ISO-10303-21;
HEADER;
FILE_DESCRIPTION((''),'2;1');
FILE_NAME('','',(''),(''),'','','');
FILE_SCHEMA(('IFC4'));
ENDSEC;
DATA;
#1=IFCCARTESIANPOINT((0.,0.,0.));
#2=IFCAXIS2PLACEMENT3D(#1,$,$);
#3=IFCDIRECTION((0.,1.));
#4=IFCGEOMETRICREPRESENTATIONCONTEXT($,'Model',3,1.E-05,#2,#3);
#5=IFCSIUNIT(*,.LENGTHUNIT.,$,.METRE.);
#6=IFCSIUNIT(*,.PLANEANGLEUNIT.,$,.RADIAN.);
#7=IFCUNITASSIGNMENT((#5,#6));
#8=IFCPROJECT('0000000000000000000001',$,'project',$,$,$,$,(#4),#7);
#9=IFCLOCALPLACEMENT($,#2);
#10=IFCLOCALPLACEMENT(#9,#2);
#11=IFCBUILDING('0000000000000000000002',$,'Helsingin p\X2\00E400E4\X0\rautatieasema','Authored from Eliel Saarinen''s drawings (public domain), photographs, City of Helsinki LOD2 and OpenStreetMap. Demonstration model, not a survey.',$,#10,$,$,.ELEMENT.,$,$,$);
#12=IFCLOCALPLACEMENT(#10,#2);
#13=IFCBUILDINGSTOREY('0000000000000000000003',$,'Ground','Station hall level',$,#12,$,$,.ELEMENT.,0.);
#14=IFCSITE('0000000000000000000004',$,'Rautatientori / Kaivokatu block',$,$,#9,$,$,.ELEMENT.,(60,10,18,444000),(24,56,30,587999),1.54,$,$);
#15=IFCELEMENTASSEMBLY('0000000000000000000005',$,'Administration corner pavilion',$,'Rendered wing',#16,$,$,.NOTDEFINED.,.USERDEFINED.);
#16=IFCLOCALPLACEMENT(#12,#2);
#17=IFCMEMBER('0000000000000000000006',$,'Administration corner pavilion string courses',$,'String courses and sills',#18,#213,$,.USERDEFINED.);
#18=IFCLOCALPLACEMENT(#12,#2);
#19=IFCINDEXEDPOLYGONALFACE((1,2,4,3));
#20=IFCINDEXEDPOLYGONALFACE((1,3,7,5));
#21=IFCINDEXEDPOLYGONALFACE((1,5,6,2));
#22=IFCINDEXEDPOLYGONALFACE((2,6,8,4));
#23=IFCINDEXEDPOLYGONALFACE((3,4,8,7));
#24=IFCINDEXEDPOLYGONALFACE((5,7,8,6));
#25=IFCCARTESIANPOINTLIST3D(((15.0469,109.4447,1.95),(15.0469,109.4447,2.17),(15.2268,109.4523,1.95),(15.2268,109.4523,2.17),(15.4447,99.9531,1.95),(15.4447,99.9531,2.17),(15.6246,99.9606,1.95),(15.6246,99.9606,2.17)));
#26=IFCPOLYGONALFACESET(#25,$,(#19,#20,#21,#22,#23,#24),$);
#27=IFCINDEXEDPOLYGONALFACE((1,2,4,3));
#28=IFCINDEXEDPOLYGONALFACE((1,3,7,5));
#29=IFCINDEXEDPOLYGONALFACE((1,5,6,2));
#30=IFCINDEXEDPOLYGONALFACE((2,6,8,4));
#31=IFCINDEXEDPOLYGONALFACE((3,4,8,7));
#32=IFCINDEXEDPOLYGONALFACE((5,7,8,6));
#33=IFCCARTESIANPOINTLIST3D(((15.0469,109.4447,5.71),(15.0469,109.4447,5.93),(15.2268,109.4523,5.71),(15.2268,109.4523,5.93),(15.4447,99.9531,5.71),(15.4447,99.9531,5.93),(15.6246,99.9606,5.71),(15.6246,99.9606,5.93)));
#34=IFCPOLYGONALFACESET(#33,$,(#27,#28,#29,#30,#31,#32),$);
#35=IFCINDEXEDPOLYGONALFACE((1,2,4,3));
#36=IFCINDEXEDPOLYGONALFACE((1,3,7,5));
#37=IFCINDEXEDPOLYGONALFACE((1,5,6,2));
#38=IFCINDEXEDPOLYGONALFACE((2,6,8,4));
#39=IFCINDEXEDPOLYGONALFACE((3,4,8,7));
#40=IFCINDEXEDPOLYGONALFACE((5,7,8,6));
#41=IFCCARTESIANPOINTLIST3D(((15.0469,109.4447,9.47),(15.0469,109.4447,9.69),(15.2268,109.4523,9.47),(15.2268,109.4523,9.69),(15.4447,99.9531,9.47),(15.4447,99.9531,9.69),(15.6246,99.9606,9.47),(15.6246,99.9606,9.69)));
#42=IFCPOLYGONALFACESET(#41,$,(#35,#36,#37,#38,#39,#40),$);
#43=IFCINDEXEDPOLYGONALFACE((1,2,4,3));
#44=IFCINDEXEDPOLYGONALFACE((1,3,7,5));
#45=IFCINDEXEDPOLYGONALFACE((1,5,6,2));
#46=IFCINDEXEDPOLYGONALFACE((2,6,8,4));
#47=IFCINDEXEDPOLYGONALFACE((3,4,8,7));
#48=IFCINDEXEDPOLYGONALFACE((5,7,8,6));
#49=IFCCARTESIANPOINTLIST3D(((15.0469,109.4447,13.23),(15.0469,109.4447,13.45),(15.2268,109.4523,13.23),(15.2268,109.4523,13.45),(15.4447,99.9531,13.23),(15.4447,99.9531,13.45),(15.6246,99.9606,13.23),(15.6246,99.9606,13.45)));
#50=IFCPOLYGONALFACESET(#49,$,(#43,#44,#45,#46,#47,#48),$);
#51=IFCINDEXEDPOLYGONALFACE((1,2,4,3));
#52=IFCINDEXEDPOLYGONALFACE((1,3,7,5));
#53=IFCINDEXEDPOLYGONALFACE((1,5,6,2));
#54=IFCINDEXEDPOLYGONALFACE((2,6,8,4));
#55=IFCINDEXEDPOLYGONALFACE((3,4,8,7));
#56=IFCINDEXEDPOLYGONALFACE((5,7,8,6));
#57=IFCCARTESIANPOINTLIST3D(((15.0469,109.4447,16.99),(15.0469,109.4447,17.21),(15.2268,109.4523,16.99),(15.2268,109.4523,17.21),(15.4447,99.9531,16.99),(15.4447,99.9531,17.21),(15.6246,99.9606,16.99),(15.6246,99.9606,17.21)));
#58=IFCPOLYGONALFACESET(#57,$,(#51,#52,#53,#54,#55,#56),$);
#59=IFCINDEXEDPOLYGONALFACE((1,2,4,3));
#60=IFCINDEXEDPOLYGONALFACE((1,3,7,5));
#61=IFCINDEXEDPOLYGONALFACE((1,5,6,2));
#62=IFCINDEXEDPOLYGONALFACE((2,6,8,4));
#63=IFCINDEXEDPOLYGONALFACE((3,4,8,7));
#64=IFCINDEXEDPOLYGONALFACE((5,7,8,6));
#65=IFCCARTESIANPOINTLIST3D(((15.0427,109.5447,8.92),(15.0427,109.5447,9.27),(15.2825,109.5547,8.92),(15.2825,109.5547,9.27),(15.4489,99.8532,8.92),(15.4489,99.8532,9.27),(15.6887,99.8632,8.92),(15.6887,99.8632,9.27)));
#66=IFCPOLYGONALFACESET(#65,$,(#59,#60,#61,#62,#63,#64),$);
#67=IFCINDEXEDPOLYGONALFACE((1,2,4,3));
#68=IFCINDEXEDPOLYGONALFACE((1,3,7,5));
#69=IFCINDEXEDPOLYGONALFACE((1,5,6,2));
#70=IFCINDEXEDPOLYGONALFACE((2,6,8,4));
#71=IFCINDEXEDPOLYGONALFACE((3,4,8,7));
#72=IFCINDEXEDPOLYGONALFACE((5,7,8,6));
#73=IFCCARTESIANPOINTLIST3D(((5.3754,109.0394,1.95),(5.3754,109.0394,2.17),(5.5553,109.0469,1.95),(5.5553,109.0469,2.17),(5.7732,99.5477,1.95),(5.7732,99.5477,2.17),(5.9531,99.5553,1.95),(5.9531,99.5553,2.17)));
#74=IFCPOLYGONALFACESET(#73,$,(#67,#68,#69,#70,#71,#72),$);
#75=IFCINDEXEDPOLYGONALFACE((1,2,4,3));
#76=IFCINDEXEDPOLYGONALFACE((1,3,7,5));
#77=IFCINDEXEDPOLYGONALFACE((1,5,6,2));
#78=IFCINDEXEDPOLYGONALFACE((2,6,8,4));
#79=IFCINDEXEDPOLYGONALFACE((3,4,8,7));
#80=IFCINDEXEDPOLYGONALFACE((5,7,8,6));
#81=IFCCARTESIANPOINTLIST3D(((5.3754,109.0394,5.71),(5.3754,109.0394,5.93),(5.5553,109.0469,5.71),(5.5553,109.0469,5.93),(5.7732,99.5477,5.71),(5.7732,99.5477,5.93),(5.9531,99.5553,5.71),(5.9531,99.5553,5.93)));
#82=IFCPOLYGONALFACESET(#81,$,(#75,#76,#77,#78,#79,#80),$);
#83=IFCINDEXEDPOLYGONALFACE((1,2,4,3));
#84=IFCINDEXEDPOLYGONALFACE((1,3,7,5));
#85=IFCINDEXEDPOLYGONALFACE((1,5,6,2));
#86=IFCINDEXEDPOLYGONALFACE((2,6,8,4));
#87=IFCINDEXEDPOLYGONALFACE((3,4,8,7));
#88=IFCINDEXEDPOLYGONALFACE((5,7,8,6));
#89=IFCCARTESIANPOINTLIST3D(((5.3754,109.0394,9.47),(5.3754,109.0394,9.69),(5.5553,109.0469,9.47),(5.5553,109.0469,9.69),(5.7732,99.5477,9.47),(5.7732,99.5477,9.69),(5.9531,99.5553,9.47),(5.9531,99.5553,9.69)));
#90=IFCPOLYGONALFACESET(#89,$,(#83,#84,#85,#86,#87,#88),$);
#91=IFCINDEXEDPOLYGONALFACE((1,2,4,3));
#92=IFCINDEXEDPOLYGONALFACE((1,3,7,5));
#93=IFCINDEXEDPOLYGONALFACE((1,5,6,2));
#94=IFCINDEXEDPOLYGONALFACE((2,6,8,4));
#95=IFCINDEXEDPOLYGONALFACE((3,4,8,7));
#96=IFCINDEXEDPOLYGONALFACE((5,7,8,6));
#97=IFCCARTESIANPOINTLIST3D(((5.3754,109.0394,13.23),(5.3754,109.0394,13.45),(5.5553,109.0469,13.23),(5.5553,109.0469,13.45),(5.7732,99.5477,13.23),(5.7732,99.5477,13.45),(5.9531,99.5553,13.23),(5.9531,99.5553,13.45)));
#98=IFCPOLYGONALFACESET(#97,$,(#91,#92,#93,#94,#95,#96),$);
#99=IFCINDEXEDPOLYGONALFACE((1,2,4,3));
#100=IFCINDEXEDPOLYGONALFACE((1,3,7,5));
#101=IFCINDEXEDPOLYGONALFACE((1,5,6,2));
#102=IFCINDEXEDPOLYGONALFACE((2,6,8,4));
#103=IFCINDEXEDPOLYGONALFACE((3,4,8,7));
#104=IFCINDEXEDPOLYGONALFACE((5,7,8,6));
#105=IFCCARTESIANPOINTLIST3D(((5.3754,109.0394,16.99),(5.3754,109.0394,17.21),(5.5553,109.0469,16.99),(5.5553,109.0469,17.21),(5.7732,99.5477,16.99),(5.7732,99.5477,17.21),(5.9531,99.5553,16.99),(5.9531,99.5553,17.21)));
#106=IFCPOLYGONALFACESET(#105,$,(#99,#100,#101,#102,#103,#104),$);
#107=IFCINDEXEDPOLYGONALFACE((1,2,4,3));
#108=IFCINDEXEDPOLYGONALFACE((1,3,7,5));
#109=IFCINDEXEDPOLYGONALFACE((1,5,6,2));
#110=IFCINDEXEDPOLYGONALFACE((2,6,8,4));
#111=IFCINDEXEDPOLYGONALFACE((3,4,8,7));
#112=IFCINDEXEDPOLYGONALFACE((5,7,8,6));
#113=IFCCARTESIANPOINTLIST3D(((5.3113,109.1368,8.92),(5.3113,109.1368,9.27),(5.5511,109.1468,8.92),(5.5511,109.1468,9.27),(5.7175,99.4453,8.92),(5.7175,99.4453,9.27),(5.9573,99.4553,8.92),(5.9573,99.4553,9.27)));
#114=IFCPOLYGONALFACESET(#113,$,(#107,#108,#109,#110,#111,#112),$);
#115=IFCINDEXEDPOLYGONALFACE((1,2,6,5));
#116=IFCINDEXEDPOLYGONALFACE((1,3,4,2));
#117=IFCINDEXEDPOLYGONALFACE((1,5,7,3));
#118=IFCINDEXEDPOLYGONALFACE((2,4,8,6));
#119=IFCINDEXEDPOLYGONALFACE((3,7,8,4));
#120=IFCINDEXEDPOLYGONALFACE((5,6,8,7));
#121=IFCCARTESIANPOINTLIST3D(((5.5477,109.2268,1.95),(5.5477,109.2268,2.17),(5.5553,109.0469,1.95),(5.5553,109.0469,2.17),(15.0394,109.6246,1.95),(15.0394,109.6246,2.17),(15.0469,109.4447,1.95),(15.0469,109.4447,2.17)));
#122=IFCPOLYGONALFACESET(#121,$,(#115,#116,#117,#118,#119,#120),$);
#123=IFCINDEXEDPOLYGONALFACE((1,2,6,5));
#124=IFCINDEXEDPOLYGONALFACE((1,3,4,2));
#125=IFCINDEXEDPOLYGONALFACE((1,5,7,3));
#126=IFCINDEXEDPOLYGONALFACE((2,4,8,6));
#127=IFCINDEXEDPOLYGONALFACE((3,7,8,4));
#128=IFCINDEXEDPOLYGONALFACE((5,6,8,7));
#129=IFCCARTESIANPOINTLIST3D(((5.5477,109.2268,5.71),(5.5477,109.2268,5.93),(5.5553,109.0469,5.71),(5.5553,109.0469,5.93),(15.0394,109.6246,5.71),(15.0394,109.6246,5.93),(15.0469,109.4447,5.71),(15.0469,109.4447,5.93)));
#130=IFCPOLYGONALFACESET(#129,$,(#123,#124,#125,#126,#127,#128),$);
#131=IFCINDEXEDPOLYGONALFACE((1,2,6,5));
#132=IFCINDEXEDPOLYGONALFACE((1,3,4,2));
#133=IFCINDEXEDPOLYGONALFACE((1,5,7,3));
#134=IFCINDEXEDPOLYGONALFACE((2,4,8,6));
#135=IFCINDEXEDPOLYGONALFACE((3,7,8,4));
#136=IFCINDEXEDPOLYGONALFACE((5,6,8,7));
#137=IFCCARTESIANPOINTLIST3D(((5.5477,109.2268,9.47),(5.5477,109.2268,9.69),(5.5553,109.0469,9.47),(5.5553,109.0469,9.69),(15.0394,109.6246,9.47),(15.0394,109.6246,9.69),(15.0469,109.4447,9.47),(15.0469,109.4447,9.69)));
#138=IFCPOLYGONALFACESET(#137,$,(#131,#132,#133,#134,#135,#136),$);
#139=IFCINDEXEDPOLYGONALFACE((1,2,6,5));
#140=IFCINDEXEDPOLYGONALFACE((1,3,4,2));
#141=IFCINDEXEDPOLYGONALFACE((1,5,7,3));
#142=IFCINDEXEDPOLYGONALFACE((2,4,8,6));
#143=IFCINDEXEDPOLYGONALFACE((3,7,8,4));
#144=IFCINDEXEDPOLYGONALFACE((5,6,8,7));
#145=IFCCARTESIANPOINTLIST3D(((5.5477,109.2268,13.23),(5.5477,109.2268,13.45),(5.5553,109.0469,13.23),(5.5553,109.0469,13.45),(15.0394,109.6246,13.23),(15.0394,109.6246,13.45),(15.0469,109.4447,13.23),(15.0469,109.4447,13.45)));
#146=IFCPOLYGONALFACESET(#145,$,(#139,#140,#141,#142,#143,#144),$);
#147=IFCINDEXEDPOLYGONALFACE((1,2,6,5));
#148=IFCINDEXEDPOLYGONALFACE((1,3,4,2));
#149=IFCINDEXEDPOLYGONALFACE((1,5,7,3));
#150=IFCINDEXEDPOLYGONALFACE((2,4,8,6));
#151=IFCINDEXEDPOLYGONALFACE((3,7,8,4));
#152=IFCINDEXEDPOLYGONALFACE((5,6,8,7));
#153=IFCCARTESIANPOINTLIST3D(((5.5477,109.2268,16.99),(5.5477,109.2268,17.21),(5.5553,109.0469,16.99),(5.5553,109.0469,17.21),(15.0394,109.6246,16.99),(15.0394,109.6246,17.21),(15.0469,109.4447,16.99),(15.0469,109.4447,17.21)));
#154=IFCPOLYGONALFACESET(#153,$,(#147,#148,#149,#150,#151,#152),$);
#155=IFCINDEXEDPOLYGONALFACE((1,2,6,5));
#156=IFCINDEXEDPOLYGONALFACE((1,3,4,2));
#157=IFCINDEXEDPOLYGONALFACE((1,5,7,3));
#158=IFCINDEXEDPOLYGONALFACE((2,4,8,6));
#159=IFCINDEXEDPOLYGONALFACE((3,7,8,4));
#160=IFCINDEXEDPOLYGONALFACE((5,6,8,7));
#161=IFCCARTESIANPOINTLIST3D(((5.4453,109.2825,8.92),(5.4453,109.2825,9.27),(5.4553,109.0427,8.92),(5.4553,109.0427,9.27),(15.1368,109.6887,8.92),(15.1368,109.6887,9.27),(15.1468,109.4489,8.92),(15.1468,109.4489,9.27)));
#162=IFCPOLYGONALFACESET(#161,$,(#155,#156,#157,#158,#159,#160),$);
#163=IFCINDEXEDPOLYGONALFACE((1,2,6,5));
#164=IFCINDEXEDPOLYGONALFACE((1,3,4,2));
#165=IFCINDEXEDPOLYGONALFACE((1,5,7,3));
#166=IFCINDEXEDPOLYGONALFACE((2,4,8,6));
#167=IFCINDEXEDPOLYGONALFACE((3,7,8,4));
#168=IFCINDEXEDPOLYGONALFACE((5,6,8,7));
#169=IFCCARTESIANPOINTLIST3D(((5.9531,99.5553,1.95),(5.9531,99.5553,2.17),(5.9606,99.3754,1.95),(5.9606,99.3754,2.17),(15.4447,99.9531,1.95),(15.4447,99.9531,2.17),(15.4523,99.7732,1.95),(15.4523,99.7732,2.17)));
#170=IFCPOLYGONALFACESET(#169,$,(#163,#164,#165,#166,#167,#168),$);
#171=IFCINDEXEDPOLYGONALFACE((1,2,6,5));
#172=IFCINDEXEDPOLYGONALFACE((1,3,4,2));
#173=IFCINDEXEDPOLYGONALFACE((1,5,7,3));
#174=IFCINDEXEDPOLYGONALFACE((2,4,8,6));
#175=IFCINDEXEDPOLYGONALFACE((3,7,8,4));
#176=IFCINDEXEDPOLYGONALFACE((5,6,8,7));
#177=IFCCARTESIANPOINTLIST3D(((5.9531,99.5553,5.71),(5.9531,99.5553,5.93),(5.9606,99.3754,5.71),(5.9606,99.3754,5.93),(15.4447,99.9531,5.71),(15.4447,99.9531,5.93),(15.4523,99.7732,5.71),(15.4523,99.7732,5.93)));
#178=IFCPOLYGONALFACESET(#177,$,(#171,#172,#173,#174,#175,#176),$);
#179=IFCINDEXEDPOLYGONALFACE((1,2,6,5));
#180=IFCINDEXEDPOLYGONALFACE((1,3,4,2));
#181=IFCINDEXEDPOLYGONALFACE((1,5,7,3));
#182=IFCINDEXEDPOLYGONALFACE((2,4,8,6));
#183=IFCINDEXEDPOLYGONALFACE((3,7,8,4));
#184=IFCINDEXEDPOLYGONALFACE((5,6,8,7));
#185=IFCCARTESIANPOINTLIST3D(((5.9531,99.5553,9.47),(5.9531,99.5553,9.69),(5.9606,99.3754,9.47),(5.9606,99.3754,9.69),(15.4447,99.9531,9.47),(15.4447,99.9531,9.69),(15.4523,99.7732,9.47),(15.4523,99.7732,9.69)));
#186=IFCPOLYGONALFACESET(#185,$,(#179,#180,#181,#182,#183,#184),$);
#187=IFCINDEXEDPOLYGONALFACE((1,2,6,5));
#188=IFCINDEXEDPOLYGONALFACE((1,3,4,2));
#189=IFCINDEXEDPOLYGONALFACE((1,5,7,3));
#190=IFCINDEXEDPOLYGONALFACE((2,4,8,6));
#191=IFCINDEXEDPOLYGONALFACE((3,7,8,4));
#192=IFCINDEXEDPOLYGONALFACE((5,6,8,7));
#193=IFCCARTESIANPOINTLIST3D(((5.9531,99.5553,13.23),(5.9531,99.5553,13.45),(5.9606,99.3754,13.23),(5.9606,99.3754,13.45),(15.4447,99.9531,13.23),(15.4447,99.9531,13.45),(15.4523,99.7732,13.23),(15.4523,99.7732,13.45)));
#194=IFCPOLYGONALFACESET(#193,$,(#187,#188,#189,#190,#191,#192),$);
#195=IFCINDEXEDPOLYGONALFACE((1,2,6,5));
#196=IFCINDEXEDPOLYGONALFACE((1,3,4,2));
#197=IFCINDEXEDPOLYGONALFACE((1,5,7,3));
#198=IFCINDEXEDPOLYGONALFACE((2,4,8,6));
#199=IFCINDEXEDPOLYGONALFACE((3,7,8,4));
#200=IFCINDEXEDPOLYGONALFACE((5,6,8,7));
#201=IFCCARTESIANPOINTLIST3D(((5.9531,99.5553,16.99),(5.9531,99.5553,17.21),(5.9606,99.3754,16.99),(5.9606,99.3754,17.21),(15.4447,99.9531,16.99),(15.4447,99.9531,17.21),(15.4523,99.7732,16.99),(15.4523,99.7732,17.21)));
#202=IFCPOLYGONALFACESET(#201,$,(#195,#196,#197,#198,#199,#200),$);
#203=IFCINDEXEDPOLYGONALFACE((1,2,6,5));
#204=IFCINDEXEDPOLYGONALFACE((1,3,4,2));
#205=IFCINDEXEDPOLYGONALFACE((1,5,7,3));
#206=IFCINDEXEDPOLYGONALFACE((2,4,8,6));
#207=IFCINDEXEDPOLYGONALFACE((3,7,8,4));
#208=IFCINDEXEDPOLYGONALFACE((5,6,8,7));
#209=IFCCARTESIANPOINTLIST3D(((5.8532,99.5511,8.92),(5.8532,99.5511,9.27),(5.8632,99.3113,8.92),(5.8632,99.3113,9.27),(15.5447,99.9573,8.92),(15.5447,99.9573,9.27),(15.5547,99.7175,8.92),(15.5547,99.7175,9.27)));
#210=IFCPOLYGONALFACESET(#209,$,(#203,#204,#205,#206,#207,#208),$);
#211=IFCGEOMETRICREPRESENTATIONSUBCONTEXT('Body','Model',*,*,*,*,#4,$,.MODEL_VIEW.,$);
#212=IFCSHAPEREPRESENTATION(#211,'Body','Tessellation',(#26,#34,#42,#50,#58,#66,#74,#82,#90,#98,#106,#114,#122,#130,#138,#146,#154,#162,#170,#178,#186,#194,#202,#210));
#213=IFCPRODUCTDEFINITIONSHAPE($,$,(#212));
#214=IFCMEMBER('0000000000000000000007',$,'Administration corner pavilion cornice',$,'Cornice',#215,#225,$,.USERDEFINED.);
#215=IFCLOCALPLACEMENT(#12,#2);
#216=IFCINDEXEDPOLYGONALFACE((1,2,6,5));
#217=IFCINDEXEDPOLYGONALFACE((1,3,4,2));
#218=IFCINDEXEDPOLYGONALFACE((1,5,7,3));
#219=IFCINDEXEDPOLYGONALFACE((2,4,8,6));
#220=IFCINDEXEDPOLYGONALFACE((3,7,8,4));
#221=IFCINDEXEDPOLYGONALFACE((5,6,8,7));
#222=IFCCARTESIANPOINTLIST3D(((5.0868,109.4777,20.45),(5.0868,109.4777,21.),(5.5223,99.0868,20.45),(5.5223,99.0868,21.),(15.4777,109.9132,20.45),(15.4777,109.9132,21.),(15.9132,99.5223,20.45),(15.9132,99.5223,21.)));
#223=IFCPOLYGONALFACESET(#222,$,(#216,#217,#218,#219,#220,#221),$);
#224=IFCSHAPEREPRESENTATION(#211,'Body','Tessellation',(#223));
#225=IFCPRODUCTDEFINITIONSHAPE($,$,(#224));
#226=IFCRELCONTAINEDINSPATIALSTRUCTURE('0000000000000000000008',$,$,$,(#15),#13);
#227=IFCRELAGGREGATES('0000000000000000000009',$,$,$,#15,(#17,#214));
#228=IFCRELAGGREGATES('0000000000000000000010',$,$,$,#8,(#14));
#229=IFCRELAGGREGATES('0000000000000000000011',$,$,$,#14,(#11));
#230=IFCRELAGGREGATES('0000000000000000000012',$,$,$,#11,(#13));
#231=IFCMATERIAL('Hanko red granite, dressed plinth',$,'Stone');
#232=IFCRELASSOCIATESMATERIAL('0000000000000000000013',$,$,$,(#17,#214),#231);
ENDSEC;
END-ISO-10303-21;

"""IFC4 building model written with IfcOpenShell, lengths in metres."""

from ifc_helpers import new_model, si_unit, direction, frame, frame_2d, origin, place, context, subcontext, project, spatial, rectangle, extrude, material, element, aggregate, save


model = new_model("IFC4")

# Units and contexts
model_context = context("Model", 3, precision=1e-05, world=origin(), true_north=direction((0.0, 1.0)))
body_context = subcontext(model_context, "Body", "Model", "MODEL_VIEW")
ifc_project = project(units=[si_unit("LENGTHUNIT", "METRE"), si_unit("PLANEANGLEUNIT", "RADIAN")], contexts=[model_context])

# Site, building, storey
site_placement = place(None, origin())
site = spatial("IfcSite", under=ifc_project, at=site_placement, Name="Rautatientori / Kaivokatu block", CompositionType="ELEMENT", RefLatitude=(60, 10, 18, 444000), RefLongitude=(24, 56, 30, 587999), RefElevation=1.54)
building_placement = place(site_placement, origin())
building = spatial("IfcBuilding", under=site, at=building_placement, Name="Helsingin päärautatieasema", Description="Authored from Eliel Saarinen's drawings (public domain), photographs, City of Helsinki LOD2 and OpenStreetMap. Demonstration model, not a survey.", CompositionType="ELEMENT")
storey_placement = place(building_placement, origin())
storey = spatial("IfcBuildingStorey", under=building, at=storey_placement, Name="Ground", Description="Station hall level", CompositionType="ELEMENT", Elevation=0.0)

# Element assembly, members
assembly_1_placement = place(building_placement, origin())
assembly_1 = element("IfcElementAssembly", 1, at=assembly_1_placement, inside=storey, Name="Administration corner pavilion", ObjectType="Rendered wing", AssemblyPlace="NOTDEFINED", PredefinedType="USERDEFINED")
ifc_material_1 = material(Name="Hanko red granite, dressed plinth", Category="Stone")
member_1_placement = place(building_placement, origin())
member_1 = element("IfcMember", 2, at=member_1_placement, material=ifc_material_1, Name="Administration corner pavilion string courses", ObjectType="String courses and sills", PredefinedType="USERDEFINED", context=body_context, shape_type="SweptSolid", body=[
    extrude(rectangle(XDim=9.5, YDim=0.18, at=frame_2d((0.0, 0.0), x_axis=(-0.041876, 0.999123))), frame((15.3358, 104.7027, 1.95)), (0.0, 0.0, 1.0), 0.22),
    extrude(rectangle(XDim=9.5, YDim=0.18, at=frame_2d((0.0, 0.0), x_axis=(-0.041876, 0.999123))), frame((15.3358, 104.7027, 5.71)), (0.0, 0.0, 1.0), 0.22),
    extrude(rectangle(XDim=9.5, YDim=0.18, at=frame_2d((0.0, 0.0), x_axis=(-0.041876, 0.999123))), frame((15.3358, 104.7027, 9.47)), (0.0, 0.0, 1.0), 0.22),
    extrude(rectangle(XDim=9.5, YDim=0.18, at=frame_2d((0.0, 0.0), x_axis=(-0.041876, 0.999123))), frame((15.3358, 104.7027, 13.23)), (0.0, 0.0, 1.0), 0.22),
    extrude(rectangle(XDim=9.5, YDim=0.18, at=frame_2d((0.0, 0.0), x_axis=(-0.041876, 0.999123))), frame((15.3358, 104.7027, 16.99)), (0.0, 0.0, 1.0), 0.22),
    extrude(rectangle(XDim=9.7, YDim=0.24, at=frame_2d((0.0, 0.0), x_axis=(-0.041876, 0.999123))), frame((15.3657, 104.7039, 8.92)), (0.0, 0.0, 1.0), 0.35),
    extrude(rectangle(XDim=9.5, YDim=0.18, at=frame_2d((0.0, 0.0), x_axis=(0.041876, -0.999123))), frame((5.6642, 104.2973, 1.95)), (0.0, 0.0, 1.0), 0.22),
    extrude(rectangle(XDim=9.5, YDim=0.18, at=frame_2d((0.0, 0.0), x_axis=(0.041876, -0.999123))), frame((5.6642, 104.2973, 5.71)), (0.0, 0.0, 1.0), 0.22),
    extrude(rectangle(XDim=9.5, YDim=0.18, at=frame_2d((0.0, 0.0), x_axis=(0.041876, -0.999123))), frame((5.6642, 104.2973, 9.47)), (0.0, 0.0, 1.0), 0.22),
    extrude(rectangle(XDim=9.5, YDim=0.18, at=frame_2d((0.0, 0.0), x_axis=(0.041876, -0.999123))), frame((5.6642, 104.2973, 13.23)), (0.0, 0.0, 1.0), 0.22),
    extrude(rectangle(XDim=9.5, YDim=0.18, at=frame_2d((0.0, 0.0), x_axis=(0.041876, -0.999123))), frame((5.6642, 104.2973, 16.99)), (0.0, 0.0, 1.0), 0.22),
    extrude(rectangle(XDim=9.7, YDim=0.24, at=frame_2d((0.0, 0.0), x_axis=(0.041876, -0.999123))), frame((5.6343, 104.2961, 8.92)), (0.0, 0.0, 1.0), 0.35),
    extrude(rectangle(XDim=9.5, YDim=0.18, at=frame_2d((0.0, 0.0), x_axis=(-0.999123, -0.041876))), frame((10.2973, 109.3358, 1.95)), (0.0, 0.0, 1.0), 0.22),
    extrude(rectangle(XDim=9.5, YDim=0.18, at=frame_2d((0.0, 0.0), x_axis=(-0.999123, -0.041876))), frame((10.2973, 109.3358, 5.71)), (0.0, 0.0, 1.0), 0.22),
    extrude(rectangle(XDim=9.5, YDim=0.18, at=frame_2d((0.0, 0.0), x_axis=(-0.999123, -0.041876))), frame((10.2973, 109.3358, 9.47)), (0.0, 0.0, 1.0), 0.22),
    extrude(rectangle(XDim=9.5, YDim=0.18, at=frame_2d((0.0, 0.0), x_axis=(-0.999123, -0.041876))), frame((10.2973, 109.3358, 13.23)), (0.0, 0.0, 1.0), 0.22),
    extrude(rectangle(XDim=9.5, YDim=0.18, at=frame_2d((0.0, 0.0), x_axis=(-0.999123, -0.041876))), frame((10.2973, 109.3358, 16.99)), (0.0, 0.0, 1.0), 0.22),
    extrude(rectangle(XDim=9.7, YDim=0.24, at=frame_2d((0.0, 0.0), x_axis=(-0.999123, -0.041876))), frame((10.2961, 109.3657, 8.92)), (0.0, 0.0, 1.0), 0.35),
    extrude(rectangle(XDim=9.5, YDim=0.18, at=frame_2d((0.0, 0.0), x_axis=(0.999123, 0.041876))), frame((10.7027, 99.6642, 1.95)), (0.0, 0.0, 1.0), 0.22),
    extrude(rectangle(XDim=9.5, YDim=0.18, at=frame_2d((0.0, 0.0), x_axis=(0.999123, 0.041876))), frame((10.7027, 99.6642, 5.71)), (0.0, 0.0, 1.0), 0.22),
    extrude(rectangle(XDim=9.5, YDim=0.18, at=frame_2d((0.0, 0.0), x_axis=(0.999123, 0.041876))), frame((10.7027, 99.6642, 9.47)), (0.0, 0.0, 1.0), 0.22),
    extrude(rectangle(XDim=9.5, YDim=0.18, at=frame_2d((0.0, 0.0), x_axis=(0.999123, 0.041876))), frame((10.7027, 99.6642, 13.23)), (0.0, 0.0, 1.0), 0.22),
    extrude(rectangle(XDim=9.5, YDim=0.18, at=frame_2d((0.0, 0.0), x_axis=(0.999123, 0.041876))), frame((10.7027, 99.6642, 16.99)), (0.0, 0.0, 1.0), 0.22),
    extrude(rectangle(XDim=9.7, YDim=0.24, at=frame_2d((0.0, 0.0), x_axis=(0.999123, 0.041876))), frame((10.7039, 99.6343, 8.92)), (0.0, 0.0, 1.0), 0.35),
])
member_2_placement = place(building_placement, origin())
member_2 = element("IfcMember", 3, at=member_2_placement, material=ifc_material_1, Name="Administration corner pavilion cornice", ObjectType="Cornice", PredefinedType="USERDEFINED", context=body_context, shape_type="SweptSolid", body=[
    extrude(rectangle(XDim=10.4, YDim=10.4, at=frame_2d((0.0, 0.0), x_axis=(0.999123, 0.041876))), frame((10.5, 104.5, 20.45)), (0.0, 0.0, 1.0), 0.55),
])
aggregate(assembly_1, [member_1, member_2])

save(model, "model.ifc")
